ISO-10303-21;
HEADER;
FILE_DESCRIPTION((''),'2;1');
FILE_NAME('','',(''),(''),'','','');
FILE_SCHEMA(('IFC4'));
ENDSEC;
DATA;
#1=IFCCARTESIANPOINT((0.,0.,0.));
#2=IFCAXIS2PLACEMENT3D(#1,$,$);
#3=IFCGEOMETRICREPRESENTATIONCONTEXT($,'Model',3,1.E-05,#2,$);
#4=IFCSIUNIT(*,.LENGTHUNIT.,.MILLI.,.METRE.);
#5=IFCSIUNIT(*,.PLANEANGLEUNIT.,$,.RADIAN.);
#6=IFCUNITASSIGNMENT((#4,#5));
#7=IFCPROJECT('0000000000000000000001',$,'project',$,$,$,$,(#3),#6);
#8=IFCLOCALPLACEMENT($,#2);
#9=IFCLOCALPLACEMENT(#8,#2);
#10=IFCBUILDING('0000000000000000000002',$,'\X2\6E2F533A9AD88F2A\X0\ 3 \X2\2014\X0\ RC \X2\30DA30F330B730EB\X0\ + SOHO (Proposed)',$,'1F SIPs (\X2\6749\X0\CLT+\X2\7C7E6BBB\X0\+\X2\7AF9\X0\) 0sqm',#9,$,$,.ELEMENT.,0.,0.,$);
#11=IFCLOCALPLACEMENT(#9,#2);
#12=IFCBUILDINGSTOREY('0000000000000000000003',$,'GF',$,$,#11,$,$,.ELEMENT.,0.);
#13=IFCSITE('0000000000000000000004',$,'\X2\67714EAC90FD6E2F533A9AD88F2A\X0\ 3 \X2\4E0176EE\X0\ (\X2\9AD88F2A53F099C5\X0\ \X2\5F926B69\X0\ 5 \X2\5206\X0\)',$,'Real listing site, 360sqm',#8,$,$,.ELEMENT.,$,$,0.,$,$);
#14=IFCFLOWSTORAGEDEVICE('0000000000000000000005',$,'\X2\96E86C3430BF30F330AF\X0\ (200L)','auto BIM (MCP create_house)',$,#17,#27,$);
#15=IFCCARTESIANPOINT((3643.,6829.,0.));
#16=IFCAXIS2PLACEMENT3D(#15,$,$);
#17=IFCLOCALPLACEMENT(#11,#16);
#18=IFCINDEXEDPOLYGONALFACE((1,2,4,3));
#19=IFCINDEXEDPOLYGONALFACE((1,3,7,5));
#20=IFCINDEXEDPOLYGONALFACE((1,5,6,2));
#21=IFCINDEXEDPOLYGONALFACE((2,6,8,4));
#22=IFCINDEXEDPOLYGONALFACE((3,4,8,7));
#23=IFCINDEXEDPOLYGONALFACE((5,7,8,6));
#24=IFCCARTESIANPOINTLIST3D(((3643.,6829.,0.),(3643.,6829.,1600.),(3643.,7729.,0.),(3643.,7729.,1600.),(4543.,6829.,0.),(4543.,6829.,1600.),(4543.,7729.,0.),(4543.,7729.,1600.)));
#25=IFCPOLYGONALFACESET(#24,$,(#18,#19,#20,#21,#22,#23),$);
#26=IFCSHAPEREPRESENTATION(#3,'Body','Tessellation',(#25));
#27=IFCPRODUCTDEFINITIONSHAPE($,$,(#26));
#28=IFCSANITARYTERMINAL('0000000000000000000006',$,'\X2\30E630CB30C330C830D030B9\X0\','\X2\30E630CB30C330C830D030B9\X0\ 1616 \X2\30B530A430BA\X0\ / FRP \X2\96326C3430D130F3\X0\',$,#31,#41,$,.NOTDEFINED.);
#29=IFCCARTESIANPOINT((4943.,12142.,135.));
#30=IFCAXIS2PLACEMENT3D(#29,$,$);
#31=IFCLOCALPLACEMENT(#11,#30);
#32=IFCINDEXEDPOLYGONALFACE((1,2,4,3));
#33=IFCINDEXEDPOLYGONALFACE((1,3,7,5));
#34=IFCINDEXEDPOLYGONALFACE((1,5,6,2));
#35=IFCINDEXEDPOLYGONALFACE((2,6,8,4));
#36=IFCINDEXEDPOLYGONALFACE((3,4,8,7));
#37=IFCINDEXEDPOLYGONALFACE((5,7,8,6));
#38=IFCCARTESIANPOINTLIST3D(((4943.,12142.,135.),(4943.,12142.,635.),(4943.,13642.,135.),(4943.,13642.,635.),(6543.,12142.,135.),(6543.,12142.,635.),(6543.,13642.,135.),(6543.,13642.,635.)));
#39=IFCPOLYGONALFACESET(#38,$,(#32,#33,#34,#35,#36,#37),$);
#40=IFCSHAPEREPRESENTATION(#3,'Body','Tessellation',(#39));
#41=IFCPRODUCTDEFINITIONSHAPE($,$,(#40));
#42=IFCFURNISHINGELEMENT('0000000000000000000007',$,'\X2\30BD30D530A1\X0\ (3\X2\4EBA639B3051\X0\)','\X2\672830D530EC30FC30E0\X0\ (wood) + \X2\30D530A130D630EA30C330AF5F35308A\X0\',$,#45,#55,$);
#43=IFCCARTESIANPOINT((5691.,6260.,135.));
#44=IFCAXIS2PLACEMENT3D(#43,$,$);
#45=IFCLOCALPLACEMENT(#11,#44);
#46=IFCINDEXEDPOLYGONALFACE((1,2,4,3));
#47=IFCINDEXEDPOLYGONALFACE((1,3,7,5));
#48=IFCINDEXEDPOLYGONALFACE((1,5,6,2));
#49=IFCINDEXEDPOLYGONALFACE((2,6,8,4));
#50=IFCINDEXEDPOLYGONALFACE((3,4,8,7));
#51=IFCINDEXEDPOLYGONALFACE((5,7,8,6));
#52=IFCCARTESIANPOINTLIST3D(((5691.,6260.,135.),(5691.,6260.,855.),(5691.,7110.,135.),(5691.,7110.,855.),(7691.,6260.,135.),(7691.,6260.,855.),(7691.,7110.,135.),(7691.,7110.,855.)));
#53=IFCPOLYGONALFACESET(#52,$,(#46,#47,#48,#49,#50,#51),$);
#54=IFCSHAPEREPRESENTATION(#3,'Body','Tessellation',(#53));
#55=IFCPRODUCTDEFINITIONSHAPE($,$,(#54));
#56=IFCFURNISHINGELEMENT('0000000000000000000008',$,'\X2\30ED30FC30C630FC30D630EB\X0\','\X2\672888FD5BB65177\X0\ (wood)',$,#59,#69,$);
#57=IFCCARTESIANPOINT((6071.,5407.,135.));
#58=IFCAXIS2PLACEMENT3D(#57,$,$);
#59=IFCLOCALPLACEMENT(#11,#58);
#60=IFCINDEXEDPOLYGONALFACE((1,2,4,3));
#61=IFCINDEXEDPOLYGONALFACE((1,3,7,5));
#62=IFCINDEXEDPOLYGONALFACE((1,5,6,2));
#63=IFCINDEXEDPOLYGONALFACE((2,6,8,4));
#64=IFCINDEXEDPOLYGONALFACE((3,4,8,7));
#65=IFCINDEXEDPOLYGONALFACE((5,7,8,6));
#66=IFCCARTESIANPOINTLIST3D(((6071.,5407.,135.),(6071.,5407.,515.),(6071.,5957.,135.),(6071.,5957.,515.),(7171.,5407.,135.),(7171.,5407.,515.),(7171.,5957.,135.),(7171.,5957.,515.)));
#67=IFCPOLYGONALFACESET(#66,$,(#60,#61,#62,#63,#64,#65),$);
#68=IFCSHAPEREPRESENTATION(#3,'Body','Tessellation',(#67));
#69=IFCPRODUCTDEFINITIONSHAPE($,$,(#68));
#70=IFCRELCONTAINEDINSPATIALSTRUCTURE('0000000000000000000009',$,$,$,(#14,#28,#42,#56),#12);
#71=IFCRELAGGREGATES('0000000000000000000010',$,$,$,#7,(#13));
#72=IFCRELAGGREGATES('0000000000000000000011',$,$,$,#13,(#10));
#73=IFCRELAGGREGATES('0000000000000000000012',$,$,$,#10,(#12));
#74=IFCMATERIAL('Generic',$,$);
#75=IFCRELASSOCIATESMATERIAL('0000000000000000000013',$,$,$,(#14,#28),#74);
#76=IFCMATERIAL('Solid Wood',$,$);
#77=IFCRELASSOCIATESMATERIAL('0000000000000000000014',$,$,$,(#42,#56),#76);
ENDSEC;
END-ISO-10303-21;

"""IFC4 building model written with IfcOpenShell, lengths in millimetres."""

from ifc_helpers import new_model, si_unit, frame, frame_2d, origin, place, context, project, spatial, rectangle, extrude, material, element, save


model = new_model("IFC4")

# Units and contexts
model_context = context("Model", 3, precision=1e-05, world=origin())
ifc_project = project(units=[si_unit("LENGTHUNIT", "METRE", prefix="MILLI"), si_unit("PLANEANGLEUNIT", "RADIAN")], contexts=[model_context])

# Site, building, storey
site_placement = place(None, origin())
site = spatial("IfcSite", under=ifc_project, at=site_placement, Name="東京都港区高輪 3 丁目 (高輪台駅 徒歩 5 分)", ObjectType="Real listing site, 360sqm", CompositionType="ELEMENT", RefElevation=0.0)
building_placement = place(site_placement, origin())
building = spatial("IfcBuilding", under=site, at=building_placement, Name="港区高輪 3 — RC ペンシル + SOHO (Proposed)", ObjectType="1F SIPs (杉CLT+籾殻+竹) 0sqm", CompositionType="ELEMENT", ElevationOfRefHeight=0.0, ElevationOfTerrain=0.0)
storey_placement = place(building_placement, origin())
storey = spatial("IfcBuildingStorey", under=building, at=storey_placement, Name="GF", CompositionType="ELEMENT", Elevation=0.0)

# Shared definitions
ifc_material_1 = material(Name="Solid Wood")

# Shared definitions
ifc_material_2 = material(Name="Generic")

# Flow storage device
flow_storage_device_placement = place(storey_placement, frame((3643.0, 6829.0, 0.0)))
element("IfcFlowStorageDevice", 1, at=flow_storage_device_placement, inside=storey, material=ifc_material_2, Name="雨水タンク (200L)", Description="auto BIM (MCP create_house)", context=model_context, shape_type="SweptSolid", body=[
    extrude(rectangle(XDim=900.0, YDim=900.0, at=frame_2d((450.0, 450.0))), frame((3643.0, 6829.0, 0.0)), (0.0, 0.0, 1.0), 1600.0),
])

# Sanitary terminal
sanitary_terminal_placement = place(storey_placement, frame((4943.0, 12142.0, 135.0)))
element("IfcSanitaryTerminal", 2, at=sanitary_terminal_placement, inside=storey, material=ifc_material_2, Name="ユニットバス", Description="ユニットバス 1616 サイズ / FRP 防水パン", PredefinedType="NOTDEFINED", context=model_context, shape_type="SweptSolid", body=[
    extrude(rectangle(XDim=1600.0, YDim=1500.0, at=frame_2d((800.0, 750.0))), frame((4943.0, 12142.0, 135.0)), (0.0, 0.0, 1.0), 500.0),
])

# Furnishing elements
furnishing_1_placement = place(storey_placement, frame((5691.0, 6260.0, 135.0)))
element("IfcFurnishingElement", 3, at=furnishing_1_placement, inside=storey, material=ifc_material_1, Name="ソファ (3人掛け)", Description="木フレーム (wood) + ファブリック張り", context=model_context, shape_type="SweptSolid", body=[
    extrude(rectangle(XDim=2000.0, YDim=850.0, at=frame_2d((1000.0, 425.0))), frame((5691.0, 6260.0, 135.0)), (0.0, 0.0, 1.0), 720.0),
])
furnishing_2_placement = place(storey_placement, frame((6071.0, 5407.0, 135.0)))
element("IfcFurnishingElement", 4, at=furnishing_2_placement, inside=storey, material=ifc_material_1, Name="ローテーブル", Description="木製家具 (wood)", context=model_context, shape_type="SweptSolid", body=[
    extrude(rectangle(XDim=1100.0, YDim=550.0, at=frame_2d((550.0, 275.0))), frame((6071.0, 5407.0, 135.0)), (0.0, 0.0, 1.0), 380.0),
])

save(model, "model.ifc")
